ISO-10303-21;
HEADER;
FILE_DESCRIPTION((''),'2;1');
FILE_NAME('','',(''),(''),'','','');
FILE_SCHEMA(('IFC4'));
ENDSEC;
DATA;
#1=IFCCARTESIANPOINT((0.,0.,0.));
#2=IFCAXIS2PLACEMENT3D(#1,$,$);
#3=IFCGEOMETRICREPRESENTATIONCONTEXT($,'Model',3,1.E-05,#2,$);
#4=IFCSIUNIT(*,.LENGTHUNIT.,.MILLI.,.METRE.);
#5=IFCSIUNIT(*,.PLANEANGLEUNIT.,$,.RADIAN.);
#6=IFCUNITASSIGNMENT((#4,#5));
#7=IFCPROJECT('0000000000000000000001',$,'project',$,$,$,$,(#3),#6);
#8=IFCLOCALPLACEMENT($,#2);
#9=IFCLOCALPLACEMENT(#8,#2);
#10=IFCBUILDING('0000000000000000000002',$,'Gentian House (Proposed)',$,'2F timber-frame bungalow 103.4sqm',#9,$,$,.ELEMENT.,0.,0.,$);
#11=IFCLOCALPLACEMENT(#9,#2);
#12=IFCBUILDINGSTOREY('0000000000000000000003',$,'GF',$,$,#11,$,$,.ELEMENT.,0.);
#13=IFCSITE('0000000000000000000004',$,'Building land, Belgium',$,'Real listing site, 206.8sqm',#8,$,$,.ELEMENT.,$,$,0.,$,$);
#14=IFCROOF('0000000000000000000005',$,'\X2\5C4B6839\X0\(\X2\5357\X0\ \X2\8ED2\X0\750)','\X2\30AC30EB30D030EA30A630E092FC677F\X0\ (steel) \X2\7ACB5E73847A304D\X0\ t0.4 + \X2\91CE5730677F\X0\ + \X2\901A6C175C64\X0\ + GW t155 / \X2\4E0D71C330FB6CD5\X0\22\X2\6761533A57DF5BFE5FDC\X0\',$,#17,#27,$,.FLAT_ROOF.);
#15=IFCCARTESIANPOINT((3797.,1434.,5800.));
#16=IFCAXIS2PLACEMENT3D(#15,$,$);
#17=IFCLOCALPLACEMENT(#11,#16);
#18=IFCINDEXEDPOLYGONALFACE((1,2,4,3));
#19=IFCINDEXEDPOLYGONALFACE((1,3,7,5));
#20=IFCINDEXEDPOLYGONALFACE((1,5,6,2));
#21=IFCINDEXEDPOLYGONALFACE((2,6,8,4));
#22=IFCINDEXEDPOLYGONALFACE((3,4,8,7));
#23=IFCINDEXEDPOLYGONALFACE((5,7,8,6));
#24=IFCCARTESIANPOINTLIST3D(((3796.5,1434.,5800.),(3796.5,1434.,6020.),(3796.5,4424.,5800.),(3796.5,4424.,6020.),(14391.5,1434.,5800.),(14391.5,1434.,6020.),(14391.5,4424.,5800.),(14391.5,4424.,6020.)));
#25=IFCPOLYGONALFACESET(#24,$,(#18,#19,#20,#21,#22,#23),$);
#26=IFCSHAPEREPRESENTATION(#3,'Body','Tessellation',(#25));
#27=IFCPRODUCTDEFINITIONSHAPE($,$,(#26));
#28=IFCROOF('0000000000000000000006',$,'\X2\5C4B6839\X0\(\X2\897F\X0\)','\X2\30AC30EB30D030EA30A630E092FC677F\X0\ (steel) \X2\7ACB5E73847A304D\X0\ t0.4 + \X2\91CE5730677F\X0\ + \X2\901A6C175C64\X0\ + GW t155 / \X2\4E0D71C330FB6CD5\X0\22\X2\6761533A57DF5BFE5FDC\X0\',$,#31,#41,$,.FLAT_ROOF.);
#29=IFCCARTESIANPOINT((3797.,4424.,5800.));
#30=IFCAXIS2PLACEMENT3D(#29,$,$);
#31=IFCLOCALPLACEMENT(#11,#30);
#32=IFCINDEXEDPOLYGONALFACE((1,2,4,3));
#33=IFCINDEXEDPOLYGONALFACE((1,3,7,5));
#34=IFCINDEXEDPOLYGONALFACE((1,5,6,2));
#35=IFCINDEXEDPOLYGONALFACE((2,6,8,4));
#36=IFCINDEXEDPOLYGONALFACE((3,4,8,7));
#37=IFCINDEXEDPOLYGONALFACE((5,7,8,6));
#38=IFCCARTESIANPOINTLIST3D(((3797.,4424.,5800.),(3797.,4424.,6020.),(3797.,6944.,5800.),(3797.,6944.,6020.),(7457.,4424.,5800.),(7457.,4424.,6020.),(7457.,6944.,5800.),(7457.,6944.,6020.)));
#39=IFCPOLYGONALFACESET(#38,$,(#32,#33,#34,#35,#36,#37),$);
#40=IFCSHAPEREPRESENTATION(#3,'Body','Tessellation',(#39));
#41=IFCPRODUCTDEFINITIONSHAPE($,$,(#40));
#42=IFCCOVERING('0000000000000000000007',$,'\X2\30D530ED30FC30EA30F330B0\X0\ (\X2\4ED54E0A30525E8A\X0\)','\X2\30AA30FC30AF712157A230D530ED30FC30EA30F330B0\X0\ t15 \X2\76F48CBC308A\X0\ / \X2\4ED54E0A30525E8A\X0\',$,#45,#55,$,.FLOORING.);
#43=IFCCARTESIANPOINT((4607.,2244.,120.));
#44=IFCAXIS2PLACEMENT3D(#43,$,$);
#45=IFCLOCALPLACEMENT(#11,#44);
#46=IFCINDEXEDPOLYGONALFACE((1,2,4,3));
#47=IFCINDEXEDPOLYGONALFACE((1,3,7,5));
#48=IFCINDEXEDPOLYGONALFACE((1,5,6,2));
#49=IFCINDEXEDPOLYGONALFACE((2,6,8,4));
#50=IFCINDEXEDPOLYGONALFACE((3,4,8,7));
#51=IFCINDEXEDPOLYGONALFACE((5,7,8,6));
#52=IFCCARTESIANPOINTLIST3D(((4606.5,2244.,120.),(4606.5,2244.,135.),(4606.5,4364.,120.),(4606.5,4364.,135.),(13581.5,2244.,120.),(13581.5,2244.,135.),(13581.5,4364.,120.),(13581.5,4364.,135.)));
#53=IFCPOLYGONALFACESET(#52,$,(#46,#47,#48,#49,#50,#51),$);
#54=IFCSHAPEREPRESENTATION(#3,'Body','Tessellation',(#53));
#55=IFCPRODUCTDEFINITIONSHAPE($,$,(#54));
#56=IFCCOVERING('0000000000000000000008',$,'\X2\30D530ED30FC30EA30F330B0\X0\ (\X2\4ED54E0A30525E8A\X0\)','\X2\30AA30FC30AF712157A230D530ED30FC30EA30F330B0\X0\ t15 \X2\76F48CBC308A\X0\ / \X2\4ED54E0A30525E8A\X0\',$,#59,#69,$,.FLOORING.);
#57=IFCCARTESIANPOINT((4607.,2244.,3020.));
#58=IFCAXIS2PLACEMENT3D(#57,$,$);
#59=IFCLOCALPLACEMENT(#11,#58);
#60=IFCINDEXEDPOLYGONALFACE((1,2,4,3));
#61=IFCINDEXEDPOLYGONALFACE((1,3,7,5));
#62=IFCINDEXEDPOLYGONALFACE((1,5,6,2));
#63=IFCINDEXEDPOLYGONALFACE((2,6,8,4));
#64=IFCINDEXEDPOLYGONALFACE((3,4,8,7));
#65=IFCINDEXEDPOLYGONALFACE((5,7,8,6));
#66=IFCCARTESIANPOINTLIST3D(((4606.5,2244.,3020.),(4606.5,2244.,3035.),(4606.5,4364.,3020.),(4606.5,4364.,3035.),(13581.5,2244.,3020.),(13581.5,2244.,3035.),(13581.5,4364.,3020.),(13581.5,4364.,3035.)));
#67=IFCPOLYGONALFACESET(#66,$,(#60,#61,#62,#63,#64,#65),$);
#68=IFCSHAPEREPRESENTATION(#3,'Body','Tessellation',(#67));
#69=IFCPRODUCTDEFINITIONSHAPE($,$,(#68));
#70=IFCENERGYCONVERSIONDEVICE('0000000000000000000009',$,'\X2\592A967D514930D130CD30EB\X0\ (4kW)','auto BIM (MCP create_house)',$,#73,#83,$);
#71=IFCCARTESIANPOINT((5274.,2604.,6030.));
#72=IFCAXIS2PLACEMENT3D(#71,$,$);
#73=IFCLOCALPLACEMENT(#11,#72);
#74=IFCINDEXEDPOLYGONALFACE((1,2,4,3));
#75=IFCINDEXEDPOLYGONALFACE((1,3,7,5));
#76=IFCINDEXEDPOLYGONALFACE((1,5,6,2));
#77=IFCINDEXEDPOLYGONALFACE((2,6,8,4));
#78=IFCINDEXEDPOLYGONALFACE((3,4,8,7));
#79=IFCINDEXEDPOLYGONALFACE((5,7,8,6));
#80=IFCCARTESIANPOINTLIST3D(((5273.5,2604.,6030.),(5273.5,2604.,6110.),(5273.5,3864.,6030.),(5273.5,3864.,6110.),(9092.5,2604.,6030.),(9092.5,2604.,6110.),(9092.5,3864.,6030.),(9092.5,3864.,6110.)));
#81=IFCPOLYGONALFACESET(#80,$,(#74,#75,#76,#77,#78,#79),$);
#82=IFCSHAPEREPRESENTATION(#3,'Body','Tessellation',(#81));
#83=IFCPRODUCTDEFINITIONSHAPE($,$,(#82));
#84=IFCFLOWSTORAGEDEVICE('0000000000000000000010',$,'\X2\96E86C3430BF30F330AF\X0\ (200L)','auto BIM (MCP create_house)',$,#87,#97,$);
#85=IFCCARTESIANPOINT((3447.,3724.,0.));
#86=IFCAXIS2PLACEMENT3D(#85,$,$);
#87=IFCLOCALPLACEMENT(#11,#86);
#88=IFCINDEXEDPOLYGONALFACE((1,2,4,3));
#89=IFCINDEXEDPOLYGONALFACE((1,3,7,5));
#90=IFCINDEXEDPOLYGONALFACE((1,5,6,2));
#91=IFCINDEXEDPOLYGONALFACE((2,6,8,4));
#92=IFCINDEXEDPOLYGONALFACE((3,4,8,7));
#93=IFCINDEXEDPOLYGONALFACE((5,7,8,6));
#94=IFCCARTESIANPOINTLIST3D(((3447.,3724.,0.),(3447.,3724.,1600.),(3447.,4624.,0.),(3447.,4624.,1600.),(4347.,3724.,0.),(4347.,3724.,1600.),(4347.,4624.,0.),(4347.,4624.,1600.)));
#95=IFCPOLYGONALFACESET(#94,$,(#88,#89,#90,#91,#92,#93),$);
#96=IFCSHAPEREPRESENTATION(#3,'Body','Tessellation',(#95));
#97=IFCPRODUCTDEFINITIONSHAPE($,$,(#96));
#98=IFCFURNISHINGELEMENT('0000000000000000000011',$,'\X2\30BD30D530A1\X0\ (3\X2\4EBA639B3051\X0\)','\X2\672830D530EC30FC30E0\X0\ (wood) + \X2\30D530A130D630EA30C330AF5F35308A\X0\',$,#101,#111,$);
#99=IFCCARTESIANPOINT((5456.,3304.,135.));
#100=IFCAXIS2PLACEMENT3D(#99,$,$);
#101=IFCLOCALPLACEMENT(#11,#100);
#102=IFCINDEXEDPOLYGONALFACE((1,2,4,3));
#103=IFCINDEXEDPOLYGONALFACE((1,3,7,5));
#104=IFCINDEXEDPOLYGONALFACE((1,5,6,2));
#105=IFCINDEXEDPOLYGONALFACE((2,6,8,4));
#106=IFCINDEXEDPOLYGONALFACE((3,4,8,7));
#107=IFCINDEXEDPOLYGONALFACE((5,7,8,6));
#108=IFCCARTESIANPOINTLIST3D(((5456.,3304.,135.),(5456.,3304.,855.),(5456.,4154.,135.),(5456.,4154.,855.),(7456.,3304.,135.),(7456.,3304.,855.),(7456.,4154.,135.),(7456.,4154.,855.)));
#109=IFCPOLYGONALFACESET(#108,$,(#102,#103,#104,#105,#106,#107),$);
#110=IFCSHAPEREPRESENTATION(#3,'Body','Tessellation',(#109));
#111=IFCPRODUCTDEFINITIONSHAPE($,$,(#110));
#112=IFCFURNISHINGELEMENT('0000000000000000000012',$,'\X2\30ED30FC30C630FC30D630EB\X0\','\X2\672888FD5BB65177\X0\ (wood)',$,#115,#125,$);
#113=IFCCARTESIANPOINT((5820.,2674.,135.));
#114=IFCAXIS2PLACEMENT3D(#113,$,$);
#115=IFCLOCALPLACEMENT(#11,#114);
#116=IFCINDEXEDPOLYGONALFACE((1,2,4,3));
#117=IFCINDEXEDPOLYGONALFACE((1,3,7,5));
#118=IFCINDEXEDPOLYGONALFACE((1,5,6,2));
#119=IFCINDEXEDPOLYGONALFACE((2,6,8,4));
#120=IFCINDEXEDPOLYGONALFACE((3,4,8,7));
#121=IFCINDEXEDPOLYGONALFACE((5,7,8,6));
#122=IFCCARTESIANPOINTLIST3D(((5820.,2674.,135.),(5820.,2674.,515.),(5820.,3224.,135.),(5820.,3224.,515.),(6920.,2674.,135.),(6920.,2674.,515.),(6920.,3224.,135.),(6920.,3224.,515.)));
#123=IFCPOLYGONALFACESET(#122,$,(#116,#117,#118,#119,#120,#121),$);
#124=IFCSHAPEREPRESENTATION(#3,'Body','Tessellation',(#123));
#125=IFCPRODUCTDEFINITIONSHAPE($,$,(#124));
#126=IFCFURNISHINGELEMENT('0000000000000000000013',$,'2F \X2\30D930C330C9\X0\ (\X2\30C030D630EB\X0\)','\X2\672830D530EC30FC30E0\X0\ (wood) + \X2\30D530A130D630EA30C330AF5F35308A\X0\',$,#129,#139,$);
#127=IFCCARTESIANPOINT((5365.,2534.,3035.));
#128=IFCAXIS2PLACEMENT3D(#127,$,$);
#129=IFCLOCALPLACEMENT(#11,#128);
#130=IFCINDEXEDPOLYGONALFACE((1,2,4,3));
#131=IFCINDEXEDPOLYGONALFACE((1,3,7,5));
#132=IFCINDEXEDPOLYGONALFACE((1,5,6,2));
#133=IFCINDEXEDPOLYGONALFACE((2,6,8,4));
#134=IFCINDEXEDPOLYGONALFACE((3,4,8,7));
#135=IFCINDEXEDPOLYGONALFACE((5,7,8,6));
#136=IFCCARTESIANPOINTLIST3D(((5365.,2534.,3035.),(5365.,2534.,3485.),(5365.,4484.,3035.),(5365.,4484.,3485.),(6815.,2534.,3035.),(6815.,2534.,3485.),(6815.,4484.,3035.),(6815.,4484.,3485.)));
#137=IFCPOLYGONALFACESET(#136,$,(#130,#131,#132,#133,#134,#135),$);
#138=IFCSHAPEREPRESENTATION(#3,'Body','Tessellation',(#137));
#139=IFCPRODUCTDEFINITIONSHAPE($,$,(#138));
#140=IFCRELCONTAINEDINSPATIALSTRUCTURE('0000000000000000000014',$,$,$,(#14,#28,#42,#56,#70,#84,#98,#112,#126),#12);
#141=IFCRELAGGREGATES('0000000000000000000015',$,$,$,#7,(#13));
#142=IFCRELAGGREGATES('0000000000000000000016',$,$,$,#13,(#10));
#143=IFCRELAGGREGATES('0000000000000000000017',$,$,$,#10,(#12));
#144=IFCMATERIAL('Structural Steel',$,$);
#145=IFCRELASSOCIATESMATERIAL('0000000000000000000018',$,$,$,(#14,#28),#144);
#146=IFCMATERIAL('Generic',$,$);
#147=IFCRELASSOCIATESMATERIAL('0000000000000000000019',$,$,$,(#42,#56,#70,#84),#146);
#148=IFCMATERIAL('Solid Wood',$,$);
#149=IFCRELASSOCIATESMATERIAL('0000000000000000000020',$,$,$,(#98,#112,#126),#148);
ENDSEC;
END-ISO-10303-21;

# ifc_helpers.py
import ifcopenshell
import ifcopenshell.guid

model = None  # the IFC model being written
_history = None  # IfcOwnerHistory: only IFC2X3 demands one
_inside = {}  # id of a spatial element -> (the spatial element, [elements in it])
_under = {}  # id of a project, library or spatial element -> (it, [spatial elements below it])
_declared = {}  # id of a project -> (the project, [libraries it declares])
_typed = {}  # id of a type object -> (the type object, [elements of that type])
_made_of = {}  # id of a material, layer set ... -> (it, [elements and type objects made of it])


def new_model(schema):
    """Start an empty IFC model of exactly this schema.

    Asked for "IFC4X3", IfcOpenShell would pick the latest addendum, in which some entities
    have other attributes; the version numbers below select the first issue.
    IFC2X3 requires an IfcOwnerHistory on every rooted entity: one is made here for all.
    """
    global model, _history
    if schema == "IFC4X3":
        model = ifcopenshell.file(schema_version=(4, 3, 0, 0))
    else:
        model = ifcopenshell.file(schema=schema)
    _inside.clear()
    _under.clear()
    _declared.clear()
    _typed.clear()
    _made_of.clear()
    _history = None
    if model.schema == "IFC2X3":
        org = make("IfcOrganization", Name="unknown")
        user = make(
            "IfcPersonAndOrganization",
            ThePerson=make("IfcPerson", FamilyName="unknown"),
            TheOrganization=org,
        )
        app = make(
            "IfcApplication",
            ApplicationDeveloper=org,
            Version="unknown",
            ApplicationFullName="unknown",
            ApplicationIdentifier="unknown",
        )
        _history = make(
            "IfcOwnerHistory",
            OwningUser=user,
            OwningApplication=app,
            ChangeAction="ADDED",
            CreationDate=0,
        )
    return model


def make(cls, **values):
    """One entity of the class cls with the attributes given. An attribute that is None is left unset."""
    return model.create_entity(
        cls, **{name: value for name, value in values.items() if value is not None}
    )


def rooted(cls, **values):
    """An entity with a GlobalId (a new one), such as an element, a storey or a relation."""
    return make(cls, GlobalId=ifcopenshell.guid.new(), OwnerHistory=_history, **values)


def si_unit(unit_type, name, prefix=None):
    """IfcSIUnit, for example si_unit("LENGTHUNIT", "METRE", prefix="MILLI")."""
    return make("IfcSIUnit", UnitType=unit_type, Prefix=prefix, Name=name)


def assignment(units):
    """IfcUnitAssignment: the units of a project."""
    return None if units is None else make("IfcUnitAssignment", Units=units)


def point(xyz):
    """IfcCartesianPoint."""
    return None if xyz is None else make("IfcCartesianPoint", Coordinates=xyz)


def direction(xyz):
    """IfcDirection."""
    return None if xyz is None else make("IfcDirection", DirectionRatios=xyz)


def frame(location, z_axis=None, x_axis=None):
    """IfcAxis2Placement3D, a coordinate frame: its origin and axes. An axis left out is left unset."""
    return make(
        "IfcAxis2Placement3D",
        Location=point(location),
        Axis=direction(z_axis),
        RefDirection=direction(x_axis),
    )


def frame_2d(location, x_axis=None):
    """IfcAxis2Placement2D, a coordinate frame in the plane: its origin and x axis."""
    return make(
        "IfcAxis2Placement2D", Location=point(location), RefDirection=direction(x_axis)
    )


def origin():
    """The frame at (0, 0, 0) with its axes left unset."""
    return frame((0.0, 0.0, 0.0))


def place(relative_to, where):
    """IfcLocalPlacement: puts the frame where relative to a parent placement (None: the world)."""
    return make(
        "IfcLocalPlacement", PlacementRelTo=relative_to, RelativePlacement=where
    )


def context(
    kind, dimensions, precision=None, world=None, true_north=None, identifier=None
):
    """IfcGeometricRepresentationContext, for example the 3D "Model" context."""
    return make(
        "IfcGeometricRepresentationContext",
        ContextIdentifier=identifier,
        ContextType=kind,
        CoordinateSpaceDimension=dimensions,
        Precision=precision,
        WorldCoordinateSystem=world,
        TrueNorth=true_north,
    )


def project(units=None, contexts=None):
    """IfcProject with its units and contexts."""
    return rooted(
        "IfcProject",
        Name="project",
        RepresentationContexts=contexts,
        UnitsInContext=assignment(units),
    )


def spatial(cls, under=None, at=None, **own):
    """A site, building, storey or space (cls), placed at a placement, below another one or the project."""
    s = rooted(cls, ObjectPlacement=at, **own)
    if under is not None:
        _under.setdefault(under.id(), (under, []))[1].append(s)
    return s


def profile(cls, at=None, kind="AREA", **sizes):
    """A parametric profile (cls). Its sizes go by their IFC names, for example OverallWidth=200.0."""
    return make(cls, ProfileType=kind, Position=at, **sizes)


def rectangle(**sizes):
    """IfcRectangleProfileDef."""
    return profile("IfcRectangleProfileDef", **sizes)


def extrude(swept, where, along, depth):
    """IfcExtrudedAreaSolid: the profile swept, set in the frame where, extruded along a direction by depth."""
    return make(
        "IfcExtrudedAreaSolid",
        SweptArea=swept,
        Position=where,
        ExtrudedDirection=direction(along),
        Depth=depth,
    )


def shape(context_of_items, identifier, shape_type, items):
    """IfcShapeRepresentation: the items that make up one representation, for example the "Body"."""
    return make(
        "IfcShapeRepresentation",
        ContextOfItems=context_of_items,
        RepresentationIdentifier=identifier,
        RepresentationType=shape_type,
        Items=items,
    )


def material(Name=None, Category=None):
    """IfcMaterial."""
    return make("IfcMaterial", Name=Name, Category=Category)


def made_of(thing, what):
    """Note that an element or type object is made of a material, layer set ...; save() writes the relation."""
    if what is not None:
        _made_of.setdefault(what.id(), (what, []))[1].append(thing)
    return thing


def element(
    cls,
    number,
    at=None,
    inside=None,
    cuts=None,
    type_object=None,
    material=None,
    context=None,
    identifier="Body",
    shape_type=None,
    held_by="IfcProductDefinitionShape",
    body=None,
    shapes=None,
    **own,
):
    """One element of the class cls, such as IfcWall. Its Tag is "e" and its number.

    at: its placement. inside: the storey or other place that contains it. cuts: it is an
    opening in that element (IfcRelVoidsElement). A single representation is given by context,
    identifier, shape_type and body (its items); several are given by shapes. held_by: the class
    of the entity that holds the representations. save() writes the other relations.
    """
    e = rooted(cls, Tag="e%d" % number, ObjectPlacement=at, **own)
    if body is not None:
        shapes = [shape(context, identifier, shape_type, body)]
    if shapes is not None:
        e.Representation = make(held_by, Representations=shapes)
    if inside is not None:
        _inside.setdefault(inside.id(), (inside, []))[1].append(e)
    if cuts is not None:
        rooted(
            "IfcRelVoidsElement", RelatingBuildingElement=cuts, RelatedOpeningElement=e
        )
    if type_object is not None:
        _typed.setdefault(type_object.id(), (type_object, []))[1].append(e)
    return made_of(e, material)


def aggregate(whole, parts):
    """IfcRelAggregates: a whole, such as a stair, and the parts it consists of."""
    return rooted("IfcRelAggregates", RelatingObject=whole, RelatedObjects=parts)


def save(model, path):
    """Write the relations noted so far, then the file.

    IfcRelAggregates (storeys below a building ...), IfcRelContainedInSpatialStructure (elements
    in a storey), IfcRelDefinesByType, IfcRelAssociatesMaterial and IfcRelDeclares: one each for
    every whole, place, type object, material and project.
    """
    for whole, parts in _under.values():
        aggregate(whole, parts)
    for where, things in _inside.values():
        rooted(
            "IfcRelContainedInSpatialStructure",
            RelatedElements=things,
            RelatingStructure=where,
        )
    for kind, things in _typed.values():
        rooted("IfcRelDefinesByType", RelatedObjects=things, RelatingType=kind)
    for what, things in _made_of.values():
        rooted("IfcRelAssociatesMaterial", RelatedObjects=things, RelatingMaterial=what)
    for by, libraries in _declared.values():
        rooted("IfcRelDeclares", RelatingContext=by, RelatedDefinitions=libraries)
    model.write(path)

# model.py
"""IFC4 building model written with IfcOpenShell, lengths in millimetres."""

from ifc_helpers import new_model, si_unit, frame, frame_2d, origin, place, context, project, spatial, rectangle, extrude, material, element, save


model = new_model("IFC4")

# Units and contexts
model_context = context("Model", 3, precision=1e-05, world=origin())
ifc_project = project(units=[si_unit("LENGTHUNIT", "METRE", prefix="MILLI"), si_unit("PLANEANGLEUNIT", "RADIAN")], contexts=[model_context])

# Site, building, storey
site_placement = place(None, origin())
site = spatial("IfcSite", under=ifc_project, at=site_placement, Name="Building land, Belgium", ObjectType="Real listing site, 206.8sqm", CompositionType="ELEMENT", RefElevation=0.0)
building_placement = place(site_placement, origin())
building = spatial("IfcBuilding", under=site, at=building_placement, Name="Gentian House (Proposed)", ObjectType="2F timber-frame bungalow 103.4sqm", CompositionType="ELEMENT", ElevationOfRefHeight=0.0, ElevationOfTerrain=0.0)
storey_placement = place(building_placement, origin())
storey = spatial("IfcBuildingStorey", under=building, at=storey_placement, Name="GF", CompositionType="ELEMENT", Elevation=0.0)

# Shared definitions
ifc_material_1 = material(Name="Solid Wood")

# Roofs
ifc_material_2 = material(Name="Structural Steel")
roof_1_placement = place(storey_placement, frame((3797.0, 1434.0, 5800.0)))
element("IfcRoof", 1, at=roof_1_placement, inside=storey, material=ifc_material_2, Name="屋根(南 軒750)", Description="ガルバリウム鋼板 (steel) 立平葺き t0.4 + 野地板 + 通気層 + GW t155 / 不燃・法22条区域対応", PredefinedType="FLAT_ROOF", context=model_context, shape_type="SweptSolid", body=[
    extrude(rectangle(XDim=10595.0, YDim=2990.0, at=frame_2d((5297.0, 1495.0))), frame((3797.0, 1434.0, 5800.0)), (0.0, 0.0, 1.0), 220.0),
])
roof_2_placement = place(storey_placement, frame((3797.0, 4424.0, 5800.0)))
element("IfcRoof", 2, at=roof_2_placement, inside=storey, material=ifc_material_2, Name="屋根(西)", Description="ガルバリウム鋼板 (steel) 立平葺き t0.4 + 野地板 + 通気層 + GW t155 / 不燃・法22条区域対応", PredefinedType="FLAT_ROOF", context=model_context, shape_type="SweptSolid", body=[
    extrude(rectangle(XDim=3660.0, YDim=2520.0, at=frame_2d((1830.0, 1260.0))), frame((3797.0, 4424.0, 5800.0)), (0.0, 0.0, 1.0), 220.0),
])

# Coverings
ifc_material_3 = material(Name="Generic")
covering_1_placement = place(storey_placement, frame((4607.0, 2244.0, 120.0)))
element("IfcCovering", 3, at=covering_1_placement, inside=storey, material=ifc_material_3, Name="フローリング (仕上げ床)", Description="オーク無垢フローリング t15 直貼り / 仕上げ床", PredefinedType="FLOORING", context=model_context, shape_type="SweptSolid", body=[
    extrude(rectangle(XDim=8975.0, YDim=2120.0, at=frame_2d((4487.0, 1060.0))), frame((4607.0, 2244.0, 120.0)), (0.0, 0.0, 1.0), 15.0),
])
covering_2_placement = place(storey_placement, frame((4607.0, 2244.0, 3020.0)))
element("IfcCovering", 4, at=covering_2_placement, inside=storey, material=ifc_material_3, Name="フローリング (仕上げ床)", Description="オーク無垢フローリング t15 直貼り / 仕上げ床", PredefinedType="FLOORING", context=model_context, shape_type="SweptSolid", body=[
    extrude(rectangle(XDim=8975.0, YDim=2120.0, at=frame_2d((4487.0, 1060.0))), frame((4607.0, 2244.0, 3020.0)), (0.0, 0.0, 1.0), 15.0),
])

# Energy conversion device
energy_conversion_device_placement = place(storey_placement, frame((5274.0, 2604.0, 6030.0)))
element("IfcEnergyConversionDevice", 5, at=energy_conversion_device_placement, inside=storey, material=ifc_material_3, Name="太陽光パネル (4kW)", Description="auto BIM (MCP create_house)", context=model_context, shape_type="SweptSolid", body=[
    extrude(rectangle(XDim=3819.0, YDim=1260.0, at=frame_2d((1909.0, 630.0))), frame((5274.0, 2604.0, 6030.0)), (0.0, 0.0, 1.0), 80.0),
])

# Flow storage device
flow_storage_device_placement = place(storey_placement, frame((3447.0, 3724.0, 0.0)))
element("IfcFlowStorageDevice", 6, at=flow_storage_device_placement, inside=storey, material=ifc_material_3, Name="雨水タンク (200L)", Description="auto BIM (MCP create_house)", context=model_context, shape_type="SweptSolid", body=[
    extrude(rectangle(XDim=900.0, YDim=900.0, at=frame_2d((450.0, 450.0))), frame((3447.0, 3724.0, 0.0)), (0.0, 0.0, 1.0), 1600.0),
])

# Furnishing elements
furnishing_1_placement = place(storey_placement, frame((5456.0, 3304.0, 135.0)))
element("IfcFurnishingElement", 7, at=furnishing_1_placement, inside=storey, material=ifc_material_1, Name="ソファ (3人掛け)", Description="木フレーム (wood) + ファブリック張り", context=model_context, shape_type="SweptSolid", body=[
    extrude(rectangle(XDim=2000.0, YDim=850.0, at=frame_2d((1000.0, 425.0))), frame((5456.0, 3304.0, 135.0)), (0.0, 0.0, 1.0), 720.0),
])
furnishing_2_placement = place(storey_placement, frame((5820.0, 2674.0, 135.0)))
element("IfcFurnishingElement", 8, at=furnishing_2_placement, inside=storey, material=ifc_material_1, Name="ローテーブル", Description="木製家具 (wood)", context=model_context, shape_type="SweptSolid", body=[
    extrude(rectangle(XDim=1100.0, YDim=550.0, at=frame_2d((550.0, 275.0))), frame((5820.0, 2674.0, 135.0)), (0.0, 0.0, 1.0), 380.0),
])
furnishing_3_placement = place(storey_placement, frame((5365.0, 2534.0, 3035.0)))
element("IfcFurnishingElement", 9, at=furnishing_3_placement, inside=storey, material=ifc_material_1, Name="2F ベッド (ダブル)", Description="木フレーム (wood) + ファブリック張り", context=model_context, shape_type="SweptSolid", body=[
    extrude(rectangle(XDim=1450.0, YDim=1950.0, at=frame_2d((725.0, 975.0))), frame((5365.0, 2534.0, 3035.0)), (0.0, 0.0, 1.0), 450.0),
])

save(model, "model.ifc")
